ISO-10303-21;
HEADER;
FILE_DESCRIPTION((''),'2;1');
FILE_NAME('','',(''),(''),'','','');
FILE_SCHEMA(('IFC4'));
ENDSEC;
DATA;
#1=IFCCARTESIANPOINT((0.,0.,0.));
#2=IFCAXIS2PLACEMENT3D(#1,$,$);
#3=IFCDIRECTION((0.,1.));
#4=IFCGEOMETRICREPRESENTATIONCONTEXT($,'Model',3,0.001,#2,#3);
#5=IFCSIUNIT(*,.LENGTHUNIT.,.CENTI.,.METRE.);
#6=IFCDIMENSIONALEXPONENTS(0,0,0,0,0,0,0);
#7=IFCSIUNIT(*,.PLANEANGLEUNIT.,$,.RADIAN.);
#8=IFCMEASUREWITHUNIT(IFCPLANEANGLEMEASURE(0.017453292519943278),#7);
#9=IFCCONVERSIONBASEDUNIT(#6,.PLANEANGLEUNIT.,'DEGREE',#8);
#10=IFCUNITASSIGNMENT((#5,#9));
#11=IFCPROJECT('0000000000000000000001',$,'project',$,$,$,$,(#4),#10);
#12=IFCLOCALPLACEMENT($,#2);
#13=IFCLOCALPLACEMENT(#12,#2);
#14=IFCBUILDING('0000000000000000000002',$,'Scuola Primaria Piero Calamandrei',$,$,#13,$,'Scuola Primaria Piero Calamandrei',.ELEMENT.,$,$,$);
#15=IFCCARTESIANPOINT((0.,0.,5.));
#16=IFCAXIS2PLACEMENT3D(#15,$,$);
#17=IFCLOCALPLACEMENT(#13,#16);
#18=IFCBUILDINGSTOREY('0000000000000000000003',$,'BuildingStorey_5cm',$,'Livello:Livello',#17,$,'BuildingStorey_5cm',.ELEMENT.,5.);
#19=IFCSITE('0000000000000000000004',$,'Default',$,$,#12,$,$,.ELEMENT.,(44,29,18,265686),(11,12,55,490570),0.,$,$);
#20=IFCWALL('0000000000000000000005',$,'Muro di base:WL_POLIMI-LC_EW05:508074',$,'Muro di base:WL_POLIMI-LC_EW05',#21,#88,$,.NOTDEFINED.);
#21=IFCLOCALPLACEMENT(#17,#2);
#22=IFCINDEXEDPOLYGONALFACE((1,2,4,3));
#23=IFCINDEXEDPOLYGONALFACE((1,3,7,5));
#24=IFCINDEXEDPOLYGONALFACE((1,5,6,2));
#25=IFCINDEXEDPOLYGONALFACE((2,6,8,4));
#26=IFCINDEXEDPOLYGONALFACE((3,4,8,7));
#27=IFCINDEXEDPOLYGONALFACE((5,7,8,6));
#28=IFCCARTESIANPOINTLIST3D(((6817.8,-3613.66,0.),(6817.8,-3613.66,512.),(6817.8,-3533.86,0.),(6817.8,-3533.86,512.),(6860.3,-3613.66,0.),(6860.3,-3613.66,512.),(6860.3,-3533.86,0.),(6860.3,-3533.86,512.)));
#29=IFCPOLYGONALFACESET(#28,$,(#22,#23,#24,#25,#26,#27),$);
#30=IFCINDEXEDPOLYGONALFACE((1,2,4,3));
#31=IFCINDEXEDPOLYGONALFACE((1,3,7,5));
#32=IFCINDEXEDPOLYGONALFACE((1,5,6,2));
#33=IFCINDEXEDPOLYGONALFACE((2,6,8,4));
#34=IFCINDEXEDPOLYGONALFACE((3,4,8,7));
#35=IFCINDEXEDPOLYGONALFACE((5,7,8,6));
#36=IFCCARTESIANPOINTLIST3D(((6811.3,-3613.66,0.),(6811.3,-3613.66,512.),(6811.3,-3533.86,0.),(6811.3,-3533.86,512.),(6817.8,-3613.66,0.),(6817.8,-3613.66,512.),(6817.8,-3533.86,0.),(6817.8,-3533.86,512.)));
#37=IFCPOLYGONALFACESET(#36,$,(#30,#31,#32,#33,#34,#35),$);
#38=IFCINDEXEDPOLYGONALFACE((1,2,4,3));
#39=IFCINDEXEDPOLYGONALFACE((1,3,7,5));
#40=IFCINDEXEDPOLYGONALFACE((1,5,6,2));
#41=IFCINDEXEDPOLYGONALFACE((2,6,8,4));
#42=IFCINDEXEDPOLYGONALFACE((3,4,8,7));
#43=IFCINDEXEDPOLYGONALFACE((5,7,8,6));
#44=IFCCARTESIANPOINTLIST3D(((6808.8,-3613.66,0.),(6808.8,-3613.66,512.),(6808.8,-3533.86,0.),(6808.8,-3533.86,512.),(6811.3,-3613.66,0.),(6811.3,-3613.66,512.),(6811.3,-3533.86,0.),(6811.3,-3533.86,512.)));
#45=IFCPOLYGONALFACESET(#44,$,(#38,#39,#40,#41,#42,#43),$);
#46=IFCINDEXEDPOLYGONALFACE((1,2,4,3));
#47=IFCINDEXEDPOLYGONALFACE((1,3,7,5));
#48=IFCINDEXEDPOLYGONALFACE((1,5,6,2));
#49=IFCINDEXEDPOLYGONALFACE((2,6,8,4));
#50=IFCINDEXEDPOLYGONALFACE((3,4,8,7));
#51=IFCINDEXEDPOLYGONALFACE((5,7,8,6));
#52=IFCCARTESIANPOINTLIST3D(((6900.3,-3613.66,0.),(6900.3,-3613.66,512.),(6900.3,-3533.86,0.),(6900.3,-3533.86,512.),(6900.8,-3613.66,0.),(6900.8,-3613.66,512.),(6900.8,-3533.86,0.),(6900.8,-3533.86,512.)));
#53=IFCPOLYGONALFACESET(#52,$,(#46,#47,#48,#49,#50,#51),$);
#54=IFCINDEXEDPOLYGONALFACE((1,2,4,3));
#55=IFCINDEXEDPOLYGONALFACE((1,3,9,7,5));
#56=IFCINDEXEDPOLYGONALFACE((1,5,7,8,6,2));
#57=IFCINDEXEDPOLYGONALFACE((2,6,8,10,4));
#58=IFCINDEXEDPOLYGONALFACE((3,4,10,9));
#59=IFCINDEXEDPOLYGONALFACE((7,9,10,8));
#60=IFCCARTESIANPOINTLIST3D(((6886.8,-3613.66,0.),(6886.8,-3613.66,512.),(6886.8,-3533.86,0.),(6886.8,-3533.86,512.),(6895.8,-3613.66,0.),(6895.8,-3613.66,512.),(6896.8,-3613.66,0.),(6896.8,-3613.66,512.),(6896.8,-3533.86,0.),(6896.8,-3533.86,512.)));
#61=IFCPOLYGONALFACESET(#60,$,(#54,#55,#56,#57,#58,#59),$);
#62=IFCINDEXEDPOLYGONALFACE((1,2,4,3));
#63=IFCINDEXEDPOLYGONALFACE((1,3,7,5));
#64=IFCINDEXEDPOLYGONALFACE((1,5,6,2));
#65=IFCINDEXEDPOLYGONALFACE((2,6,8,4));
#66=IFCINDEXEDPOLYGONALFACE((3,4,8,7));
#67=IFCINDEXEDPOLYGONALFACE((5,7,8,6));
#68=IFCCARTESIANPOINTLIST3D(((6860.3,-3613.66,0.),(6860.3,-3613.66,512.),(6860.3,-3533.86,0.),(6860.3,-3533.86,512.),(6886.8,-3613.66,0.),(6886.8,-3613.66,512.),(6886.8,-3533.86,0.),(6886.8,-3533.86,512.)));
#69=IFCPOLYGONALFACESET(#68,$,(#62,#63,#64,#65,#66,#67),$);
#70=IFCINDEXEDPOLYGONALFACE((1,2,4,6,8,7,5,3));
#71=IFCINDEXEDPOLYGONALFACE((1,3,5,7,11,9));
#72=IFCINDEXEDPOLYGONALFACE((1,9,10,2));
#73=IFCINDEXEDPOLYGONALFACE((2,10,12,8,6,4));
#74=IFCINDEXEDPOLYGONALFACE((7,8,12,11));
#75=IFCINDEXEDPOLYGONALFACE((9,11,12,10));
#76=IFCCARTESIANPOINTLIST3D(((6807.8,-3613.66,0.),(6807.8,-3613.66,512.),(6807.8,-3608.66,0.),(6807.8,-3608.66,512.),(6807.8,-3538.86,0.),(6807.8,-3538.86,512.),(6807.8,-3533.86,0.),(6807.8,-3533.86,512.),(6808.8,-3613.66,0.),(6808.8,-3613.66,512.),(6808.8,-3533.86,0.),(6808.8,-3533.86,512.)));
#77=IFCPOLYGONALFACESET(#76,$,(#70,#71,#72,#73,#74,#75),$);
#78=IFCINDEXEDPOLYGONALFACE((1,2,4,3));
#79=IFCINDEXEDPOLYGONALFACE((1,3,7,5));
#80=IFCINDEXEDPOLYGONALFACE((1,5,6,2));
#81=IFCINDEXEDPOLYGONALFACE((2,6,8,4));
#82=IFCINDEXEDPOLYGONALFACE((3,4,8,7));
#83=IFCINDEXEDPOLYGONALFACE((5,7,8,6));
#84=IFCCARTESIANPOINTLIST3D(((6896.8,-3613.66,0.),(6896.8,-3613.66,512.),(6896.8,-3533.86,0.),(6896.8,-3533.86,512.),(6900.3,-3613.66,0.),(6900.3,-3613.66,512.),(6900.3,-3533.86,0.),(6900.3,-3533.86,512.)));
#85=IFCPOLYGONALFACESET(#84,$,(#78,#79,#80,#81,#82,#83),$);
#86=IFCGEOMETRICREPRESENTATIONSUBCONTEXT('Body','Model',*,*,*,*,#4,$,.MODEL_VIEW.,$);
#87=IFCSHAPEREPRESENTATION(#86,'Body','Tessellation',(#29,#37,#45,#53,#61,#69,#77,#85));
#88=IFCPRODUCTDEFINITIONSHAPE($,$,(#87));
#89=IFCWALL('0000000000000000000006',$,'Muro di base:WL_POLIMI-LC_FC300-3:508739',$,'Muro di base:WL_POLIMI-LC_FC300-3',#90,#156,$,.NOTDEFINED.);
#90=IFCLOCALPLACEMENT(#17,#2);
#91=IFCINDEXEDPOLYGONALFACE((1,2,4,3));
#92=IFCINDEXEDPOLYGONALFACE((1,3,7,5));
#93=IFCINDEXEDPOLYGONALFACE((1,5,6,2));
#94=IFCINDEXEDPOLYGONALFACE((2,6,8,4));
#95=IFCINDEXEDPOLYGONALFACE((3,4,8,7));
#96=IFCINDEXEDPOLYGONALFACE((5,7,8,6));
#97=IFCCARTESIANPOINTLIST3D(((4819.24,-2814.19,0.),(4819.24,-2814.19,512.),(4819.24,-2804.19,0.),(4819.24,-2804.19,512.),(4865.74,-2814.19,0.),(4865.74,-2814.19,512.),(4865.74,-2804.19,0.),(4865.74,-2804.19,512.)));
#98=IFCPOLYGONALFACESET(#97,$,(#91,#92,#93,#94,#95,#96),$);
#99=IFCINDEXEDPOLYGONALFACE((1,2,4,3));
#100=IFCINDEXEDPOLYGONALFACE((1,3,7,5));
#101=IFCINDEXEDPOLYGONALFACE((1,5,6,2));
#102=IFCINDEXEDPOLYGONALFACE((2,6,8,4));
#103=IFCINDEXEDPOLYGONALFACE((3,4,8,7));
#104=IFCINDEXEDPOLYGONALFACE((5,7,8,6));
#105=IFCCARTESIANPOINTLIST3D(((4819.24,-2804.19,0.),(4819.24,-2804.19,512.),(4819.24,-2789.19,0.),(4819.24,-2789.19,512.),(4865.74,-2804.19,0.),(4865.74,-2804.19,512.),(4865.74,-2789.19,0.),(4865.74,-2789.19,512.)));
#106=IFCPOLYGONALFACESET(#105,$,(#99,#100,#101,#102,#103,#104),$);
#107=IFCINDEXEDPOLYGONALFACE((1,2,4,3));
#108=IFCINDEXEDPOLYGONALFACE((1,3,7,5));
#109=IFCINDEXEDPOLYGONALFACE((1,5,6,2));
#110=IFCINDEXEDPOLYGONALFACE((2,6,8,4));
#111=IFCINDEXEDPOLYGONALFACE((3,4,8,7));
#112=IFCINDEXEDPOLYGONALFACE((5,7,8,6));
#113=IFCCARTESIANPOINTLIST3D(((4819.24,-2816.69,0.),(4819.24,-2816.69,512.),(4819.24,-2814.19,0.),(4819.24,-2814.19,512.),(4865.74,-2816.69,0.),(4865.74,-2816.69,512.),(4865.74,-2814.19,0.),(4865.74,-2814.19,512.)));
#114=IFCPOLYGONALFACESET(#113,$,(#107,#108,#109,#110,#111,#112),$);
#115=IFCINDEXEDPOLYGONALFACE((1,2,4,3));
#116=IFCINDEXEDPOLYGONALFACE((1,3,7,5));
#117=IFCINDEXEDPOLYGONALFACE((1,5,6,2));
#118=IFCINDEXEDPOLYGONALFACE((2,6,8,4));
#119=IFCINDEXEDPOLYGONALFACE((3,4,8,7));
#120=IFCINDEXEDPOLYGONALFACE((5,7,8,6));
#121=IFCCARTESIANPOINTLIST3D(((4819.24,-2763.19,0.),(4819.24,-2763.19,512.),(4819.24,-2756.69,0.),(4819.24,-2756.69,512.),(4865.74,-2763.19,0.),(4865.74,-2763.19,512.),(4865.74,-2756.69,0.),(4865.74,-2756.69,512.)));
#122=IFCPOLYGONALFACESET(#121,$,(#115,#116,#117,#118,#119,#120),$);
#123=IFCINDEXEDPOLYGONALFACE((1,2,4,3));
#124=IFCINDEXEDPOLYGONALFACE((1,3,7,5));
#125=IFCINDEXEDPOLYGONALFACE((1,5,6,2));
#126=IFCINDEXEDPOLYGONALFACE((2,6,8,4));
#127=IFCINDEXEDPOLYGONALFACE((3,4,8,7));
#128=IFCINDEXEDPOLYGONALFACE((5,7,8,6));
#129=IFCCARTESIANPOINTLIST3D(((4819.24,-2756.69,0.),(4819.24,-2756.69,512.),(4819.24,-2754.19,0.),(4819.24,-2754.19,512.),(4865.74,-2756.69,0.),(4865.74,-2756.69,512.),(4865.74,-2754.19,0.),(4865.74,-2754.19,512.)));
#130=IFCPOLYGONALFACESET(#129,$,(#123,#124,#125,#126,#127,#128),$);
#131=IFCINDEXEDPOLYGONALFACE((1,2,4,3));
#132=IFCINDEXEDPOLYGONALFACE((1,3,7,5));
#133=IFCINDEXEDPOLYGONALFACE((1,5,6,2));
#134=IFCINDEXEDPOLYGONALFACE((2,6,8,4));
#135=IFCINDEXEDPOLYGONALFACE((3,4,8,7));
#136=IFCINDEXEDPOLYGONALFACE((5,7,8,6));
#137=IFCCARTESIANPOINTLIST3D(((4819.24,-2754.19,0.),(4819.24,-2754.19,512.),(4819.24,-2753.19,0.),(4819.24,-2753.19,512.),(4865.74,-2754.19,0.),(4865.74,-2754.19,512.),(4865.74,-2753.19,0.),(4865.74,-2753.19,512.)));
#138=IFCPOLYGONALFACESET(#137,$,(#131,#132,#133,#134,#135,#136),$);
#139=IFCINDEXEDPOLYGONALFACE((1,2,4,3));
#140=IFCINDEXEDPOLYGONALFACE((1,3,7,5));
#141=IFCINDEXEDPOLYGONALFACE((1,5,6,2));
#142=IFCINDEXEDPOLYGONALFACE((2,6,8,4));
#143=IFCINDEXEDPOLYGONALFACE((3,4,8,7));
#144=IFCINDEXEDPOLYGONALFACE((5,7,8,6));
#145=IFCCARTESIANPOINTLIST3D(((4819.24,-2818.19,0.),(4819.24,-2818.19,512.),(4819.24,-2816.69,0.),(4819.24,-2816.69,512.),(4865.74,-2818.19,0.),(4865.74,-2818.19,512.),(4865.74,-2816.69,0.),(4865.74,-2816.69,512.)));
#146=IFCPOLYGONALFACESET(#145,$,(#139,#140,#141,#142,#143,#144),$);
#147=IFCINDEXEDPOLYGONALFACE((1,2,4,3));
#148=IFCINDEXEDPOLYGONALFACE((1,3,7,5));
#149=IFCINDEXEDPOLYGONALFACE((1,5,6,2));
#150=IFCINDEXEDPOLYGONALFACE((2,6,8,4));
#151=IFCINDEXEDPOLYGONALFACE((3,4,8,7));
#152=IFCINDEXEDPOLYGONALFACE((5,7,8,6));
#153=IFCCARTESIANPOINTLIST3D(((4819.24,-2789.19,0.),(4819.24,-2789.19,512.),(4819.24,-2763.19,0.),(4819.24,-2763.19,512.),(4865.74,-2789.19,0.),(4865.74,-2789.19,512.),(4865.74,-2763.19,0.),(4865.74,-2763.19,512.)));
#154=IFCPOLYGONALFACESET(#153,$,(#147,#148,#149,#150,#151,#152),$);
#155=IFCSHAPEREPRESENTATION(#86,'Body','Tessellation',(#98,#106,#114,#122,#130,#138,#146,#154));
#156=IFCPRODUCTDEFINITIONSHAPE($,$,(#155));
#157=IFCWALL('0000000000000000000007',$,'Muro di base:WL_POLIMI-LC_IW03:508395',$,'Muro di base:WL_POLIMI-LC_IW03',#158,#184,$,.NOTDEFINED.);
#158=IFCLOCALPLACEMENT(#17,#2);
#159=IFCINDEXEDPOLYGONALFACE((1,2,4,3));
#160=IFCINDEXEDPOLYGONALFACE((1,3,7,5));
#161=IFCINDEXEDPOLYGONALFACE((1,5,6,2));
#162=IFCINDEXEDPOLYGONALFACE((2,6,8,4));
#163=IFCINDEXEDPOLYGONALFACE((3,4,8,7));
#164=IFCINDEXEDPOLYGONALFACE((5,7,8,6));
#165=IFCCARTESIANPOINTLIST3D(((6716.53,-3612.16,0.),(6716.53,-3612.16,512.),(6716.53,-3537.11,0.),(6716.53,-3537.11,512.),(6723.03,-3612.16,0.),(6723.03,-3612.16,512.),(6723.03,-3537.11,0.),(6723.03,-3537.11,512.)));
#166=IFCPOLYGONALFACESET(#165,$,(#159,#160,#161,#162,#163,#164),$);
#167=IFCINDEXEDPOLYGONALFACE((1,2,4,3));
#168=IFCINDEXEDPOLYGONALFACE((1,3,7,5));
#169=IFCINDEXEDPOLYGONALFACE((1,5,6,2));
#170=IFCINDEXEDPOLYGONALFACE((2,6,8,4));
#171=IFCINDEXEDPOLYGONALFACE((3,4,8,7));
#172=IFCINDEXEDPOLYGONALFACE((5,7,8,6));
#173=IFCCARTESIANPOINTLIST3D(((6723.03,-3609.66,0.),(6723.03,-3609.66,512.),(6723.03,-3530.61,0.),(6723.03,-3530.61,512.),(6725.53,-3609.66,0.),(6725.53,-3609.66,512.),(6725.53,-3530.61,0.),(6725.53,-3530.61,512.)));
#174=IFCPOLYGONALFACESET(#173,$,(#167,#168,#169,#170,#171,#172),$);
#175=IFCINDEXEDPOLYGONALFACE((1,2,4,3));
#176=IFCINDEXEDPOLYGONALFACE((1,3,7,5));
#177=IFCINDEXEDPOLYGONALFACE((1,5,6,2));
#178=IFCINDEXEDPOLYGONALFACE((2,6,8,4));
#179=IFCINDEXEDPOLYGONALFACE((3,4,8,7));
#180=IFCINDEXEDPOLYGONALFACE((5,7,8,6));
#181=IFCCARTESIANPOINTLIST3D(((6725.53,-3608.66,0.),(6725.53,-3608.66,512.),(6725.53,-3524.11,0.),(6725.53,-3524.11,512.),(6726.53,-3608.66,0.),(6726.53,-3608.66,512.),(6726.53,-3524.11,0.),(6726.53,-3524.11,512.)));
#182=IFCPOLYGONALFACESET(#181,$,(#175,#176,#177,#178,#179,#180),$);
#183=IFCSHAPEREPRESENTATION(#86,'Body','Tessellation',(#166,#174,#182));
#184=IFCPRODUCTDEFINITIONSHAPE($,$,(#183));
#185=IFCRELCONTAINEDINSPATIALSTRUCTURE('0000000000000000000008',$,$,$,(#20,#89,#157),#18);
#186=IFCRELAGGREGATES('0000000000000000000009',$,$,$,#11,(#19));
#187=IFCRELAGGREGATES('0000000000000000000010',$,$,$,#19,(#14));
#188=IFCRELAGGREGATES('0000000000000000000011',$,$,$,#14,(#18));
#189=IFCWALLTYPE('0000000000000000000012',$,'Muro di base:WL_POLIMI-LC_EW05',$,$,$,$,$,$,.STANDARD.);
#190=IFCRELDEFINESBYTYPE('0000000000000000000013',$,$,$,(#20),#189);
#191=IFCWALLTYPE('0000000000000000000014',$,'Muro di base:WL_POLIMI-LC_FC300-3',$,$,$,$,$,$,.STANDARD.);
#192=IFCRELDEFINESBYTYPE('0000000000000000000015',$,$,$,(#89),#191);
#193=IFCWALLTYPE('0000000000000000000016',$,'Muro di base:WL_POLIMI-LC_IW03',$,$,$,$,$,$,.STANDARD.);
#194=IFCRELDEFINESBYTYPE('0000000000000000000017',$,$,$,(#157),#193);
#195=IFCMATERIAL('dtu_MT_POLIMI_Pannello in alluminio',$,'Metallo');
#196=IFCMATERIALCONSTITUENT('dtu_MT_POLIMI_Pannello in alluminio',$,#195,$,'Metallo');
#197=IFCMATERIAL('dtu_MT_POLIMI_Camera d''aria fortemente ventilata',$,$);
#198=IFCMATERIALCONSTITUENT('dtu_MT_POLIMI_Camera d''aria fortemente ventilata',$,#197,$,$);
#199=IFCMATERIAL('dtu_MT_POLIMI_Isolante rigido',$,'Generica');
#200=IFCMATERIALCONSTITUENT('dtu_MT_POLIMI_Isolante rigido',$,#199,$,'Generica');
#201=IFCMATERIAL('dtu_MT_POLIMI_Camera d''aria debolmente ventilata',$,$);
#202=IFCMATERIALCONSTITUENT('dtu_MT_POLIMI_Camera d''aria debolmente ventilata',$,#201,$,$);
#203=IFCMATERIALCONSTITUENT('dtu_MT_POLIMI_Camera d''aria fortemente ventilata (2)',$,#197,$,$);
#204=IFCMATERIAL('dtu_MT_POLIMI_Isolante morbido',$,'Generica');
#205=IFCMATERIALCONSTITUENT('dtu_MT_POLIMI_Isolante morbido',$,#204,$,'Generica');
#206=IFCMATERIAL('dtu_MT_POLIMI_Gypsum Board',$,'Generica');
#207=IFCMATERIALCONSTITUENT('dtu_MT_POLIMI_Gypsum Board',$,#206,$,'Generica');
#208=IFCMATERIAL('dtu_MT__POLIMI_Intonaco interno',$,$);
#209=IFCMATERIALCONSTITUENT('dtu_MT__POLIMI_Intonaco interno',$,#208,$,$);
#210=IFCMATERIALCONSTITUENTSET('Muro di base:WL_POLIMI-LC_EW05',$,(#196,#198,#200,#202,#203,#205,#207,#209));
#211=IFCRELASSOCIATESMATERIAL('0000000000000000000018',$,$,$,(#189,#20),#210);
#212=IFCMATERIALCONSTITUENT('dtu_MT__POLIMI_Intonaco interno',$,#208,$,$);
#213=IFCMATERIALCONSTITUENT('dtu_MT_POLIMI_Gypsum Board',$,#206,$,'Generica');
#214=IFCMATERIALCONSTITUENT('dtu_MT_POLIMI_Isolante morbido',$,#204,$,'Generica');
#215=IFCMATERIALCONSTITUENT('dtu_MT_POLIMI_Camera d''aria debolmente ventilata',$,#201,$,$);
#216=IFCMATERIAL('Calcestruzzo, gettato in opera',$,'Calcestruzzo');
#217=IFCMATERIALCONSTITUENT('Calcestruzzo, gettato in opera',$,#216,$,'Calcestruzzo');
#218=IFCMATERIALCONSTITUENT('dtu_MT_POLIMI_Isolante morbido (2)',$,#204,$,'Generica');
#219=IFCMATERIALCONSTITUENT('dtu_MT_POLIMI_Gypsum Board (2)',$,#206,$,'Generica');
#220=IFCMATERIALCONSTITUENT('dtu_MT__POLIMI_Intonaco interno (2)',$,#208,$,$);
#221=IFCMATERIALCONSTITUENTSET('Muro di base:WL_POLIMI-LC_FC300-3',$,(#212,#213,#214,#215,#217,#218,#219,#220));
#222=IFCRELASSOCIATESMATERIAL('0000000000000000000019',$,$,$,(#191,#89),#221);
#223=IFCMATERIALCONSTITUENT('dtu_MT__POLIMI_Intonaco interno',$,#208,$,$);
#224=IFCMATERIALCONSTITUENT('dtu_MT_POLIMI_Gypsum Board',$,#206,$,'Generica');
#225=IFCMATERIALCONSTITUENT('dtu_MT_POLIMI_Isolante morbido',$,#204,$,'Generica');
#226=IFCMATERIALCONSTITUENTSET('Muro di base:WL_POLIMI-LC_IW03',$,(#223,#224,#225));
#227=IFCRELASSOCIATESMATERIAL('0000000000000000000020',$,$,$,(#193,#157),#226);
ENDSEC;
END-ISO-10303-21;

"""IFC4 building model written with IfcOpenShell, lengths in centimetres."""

from ifc_helpers import new_model, entity, si_unit, converted_unit, direction, frame, origin, place, context, subcontext, project, spatial, indexed_curve, outline, extrude, material, constituent, constituent_set, type_object, element, save


model = new_model("IFC4")

# Units and contexts
model_context = context("Model", 3, precision=0.001, world=origin(), true_north=direction((0.0, 1.0)))
body_context = subcontext(model_context, "Body", "Model", "MODEL_VIEW")
ifc_project = project(units=[si_unit("LENGTHUNIT", "METRE", prefix="CENTI"), converted_unit("PLANEANGLEUNIT", "DEGREE", entity("IfcPlaneAngleMeasure", 0.017453292519943278), si_unit("PLANEANGLEUNIT", "RADIAN"), dimensions=[0, 0, 0, 0, 0, 0, 0])], contexts=[model_context])

# Site, building, storey
site_placement = place(None, origin())
site = spatial("IfcSite", under=ifc_project, at=site_placement, Name="Default", CompositionType="ELEMENT", RefLatitude=(44, 29, 18, 265686), RefLongitude=(11, 12, 55, 490570), RefElevation=0.0)
building_placement = place(site_placement, origin())
building = spatial("IfcBuilding", under=site, at=building_placement, Name="Scuola Primaria Piero Calamandrei", LongName="Scuola Primaria Piero Calamandrei", CompositionType="ELEMENT")
storey_placement = place(building_placement, frame((0.0, 0.0, 5.0)))
storey = spatial("IfcBuildingStorey", under=building, at=storey_placement, Name="BuildingStorey_5cm", ObjectType="Livello:Livello", LongName="BuildingStorey_5cm", CompositionType="ELEMENT", Elevation=5.0)

# Shared definitions
ifc_material_1 = material(Name="dtu_MT_POLIMI_Isolante rigido", Category="Generica")

# Walls
ifc_material_2 = material(Name="dtu_MT_POLIMI_Pannello in alluminio", Category="Metallo")
ifc_constituent_1 = constituent(ifc_material_2, Name="dtu_MT_POLIMI_Pannello in alluminio", Category="Metallo")
ifc_material_3 = material(Name="dtu_MT_POLIMI_Camera d'aria fortemente ventilata")
ifc_constituent_2 = constituent(ifc_material_3, Name="dtu_MT_POLIMI_Camera d'aria fortemente ventilata")
ifc_constituent_3 = constituent(ifc_material_1, Name="dtu_MT_POLIMI_Isolante rigido", Category="Generica")
ifc_material_4 = material(Name="dtu_MT_POLIMI_Camera d'aria debolmente ventilata")
ifc_constituent_4 = constituent(ifc_material_4, Name="dtu_MT_POLIMI_Camera d'aria debolmente ventilata")
ifc_constituent_5 = constituent(ifc_material_3, Name="dtu_MT_POLIMI_Camera d'aria fortemente ventilata (2)")
ifc_material_5 = material(Name="dtu_MT_POLIMI_Isolante morbido", Category="Generica")
ifc_constituent_6 = constituent(ifc_material_5, Name="dtu_MT_POLIMI_Isolante morbido", Category="Generica")
ifc_material_6 = material(Name="dtu_MT_POLIMI_Gypsum Board", Category="Generica")
ifc_constituent_7 = constituent(ifc_material_6, Name="dtu_MT_POLIMI_Gypsum Board", Category="Generica")
ifc_material_7 = material(Name="dtu_MT__POLIMI_Intonaco interno")
ifc_constituent_8 = constituent(ifc_material_7, Name="dtu_MT__POLIMI_Intonaco interno")
ifc_constituent_set_1 = constituent_set(constituents=[ifc_constituent_1, ifc_constituent_2, ifc_constituent_3, ifc_constituent_4, ifc_constituent_5, ifc_constituent_6, ifc_constituent_7, ifc_constituent_8], Name="Muro di base:WL_POLIMI-LC_EW05")
wall_type_1 = type_object("IfcWallType", Name="Muro di base:WL_POLIMI-LC_EW05", PredefinedType="STANDARD", material=ifc_constituent_set_1)
wall_1_placement = place(storey_placement, frame((6854.3, -3533.86, 0.0), z_axis=(0.0, 0.0, 1.0), x_axis=(0.0, -1.0, 0.0)))
element("IfcWall", 1, at=wall_1_placement, inside=storey, type_object=wall_type_1, material=ifc_constituent_set_1, Name="Muro di base:WL_POLIMI-LC_EW05:508074", ObjectType="Muro di base:WL_POLIMI-LC_EW05", PredefinedType="NOTDEFINED", context=body_context, shape_type="SweptSolid", body=[
    extrude(outline(indexed_curve([(-39.9, -21.25), (39.9, -21.25), (39.9, 21.25), (-39.9, 21.25), (-39.9, -21.25)], self_intersect=False)), frame((39.9, -15.25, 0.0)), (0.0, 0.0, 1.0), 512.0),
    extrude(outline(indexed_curve([(-39.9, -3.25), (39.9, -3.25), (39.9, 3.25), (-39.9, 3.25), (-39.9, -3.25)], self_intersect=False)), frame((39.9, -39.75, 0.0)), (0.0, 0.0, 1.0), 512.0),
    extrude(outline(indexed_curve([(-39.9, -1.25), (39.9, -1.25), (39.9, 1.25), (-39.9, 1.25), (-39.9, -1.25)], self_intersect=False)), frame((39.9, -44.25, 0.0)), (0.0, 0.0, 1.0), 512.0),
    extrude(outline(indexed_curve([(-0.25, -39.9), (0.25, -39.9), (0.25, 39.9), (-0.25, 39.9), (-0.25, -39.9)], self_intersect=False)), frame((39.9, 46.25, 0.0), z_axis=(0.0, 0.0, 1.0), x_axis=(0.0, -1.0, 0.0)), (0.0, 0.0, 1.0), 512.0),
    extrude(outline(indexed_curve([(-47.88, -5.8), (31.92, -5.8), (31.92, 3.2), (31.92, 4.2), (-47.88, 4.2), (-47.88, -5.8)], self_intersect=False)), frame((47.88, 38.3, 0.0)), (0.0, 0.0, 1.0), 512.0),
    extrude(outline(indexed_curve([(-39.9, -13.25), (39.9, -13.25), (39.9, 13.25), (-39.9, 13.25), (-39.9, -13.25)], self_intersect=False)), frame((39.9, 19.25, 0.0)), (0.0, 0.0, 1.0), 512.0),
    extrude(outline(indexed_curve([(-34.9, -0.33), (34.9, -0.33), (39.9, -0.33), (39.9, 0.67), (-39.9, 0.67), (-39.9, -0.33), (-34.9, -0.33)], self_intersect=False)), frame((39.9, -46.17, 0.0)), (0.0, 0.0, 1.0), 512.0),
    extrude(outline(indexed_curve([(-39.9, -1.75), (39.9, -1.75), (39.9, 1.75), (-39.9, 1.75), (-39.9, -1.75)], self_intersect=False)), frame((39.9, 44.25, 0.0)), (0.0, 0.0, 1.0), 512.0),
])
ifc_constituent_9 = constituent(ifc_material_7, Name="dtu_MT__POLIMI_Intonaco interno")
ifc_constituent_10 = constituent(ifc_material_6, Name="dtu_MT_POLIMI_Gypsum Board", Category="Generica")
ifc_constituent_11 = constituent(ifc_material_5, Name="dtu_MT_POLIMI_Isolante morbido", Category="Generica")
ifc_constituent_12 = constituent(ifc_material_4, Name="dtu_MT_POLIMI_Camera d'aria debolmente ventilata")
ifc_material_8 = material(Name="Calcestruzzo, gettato in opera", Category="Calcestruzzo")
ifc_constituent_13 = constituent(ifc_material_8, Name="Calcestruzzo, gettato in opera", Category="Calcestruzzo")
ifc_constituent_14 = constituent(ifc_material_5, Name="dtu_MT_POLIMI_Isolante morbido (2)", Category="Generica")
ifc_constituent_15 = constituent(ifc_material_6, Name="dtu_MT_POLIMI_Gypsum Board (2)", Category="Generica")
ifc_constituent_16 = constituent(ifc_material_7, Name="dtu_MT__POLIMI_Intonaco interno (2)")
ifc_constituent_set_2 = constituent_set(constituents=[ifc_constituent_9, ifc_constituent_10, ifc_constituent_11, ifc_constituent_12, ifc_constituent_13, ifc_constituent_14, ifc_constituent_15, ifc_constituent_16], Name="Muro di base:WL_POLIMI-LC_FC300-3")
wall_type_2 = type_object("IfcWallType", Name="Muro di base:WL_POLIMI-LC_FC300-3", PredefinedType="STANDARD", material=ifc_constituent_set_2)
wall_2_placement = place(storey_placement, frame((4865.74, -2785.69, 0.0), z_axis=(0.0, 0.0, 1.0), x_axis=(-1.0, 0.0, 0.0)))
element("IfcWall", 2, at=wall_2_placement, inside=storey, type_object=wall_type_2, material=ifc_constituent_set_2, Name="Muro di base:WL_POLIMI-LC_FC300-3:508739", ObjectType="Muro di base:WL_POLIMI-LC_FC300-3", PredefinedType="NOTDEFINED", context=body_context, shape_type="SweptSolid", body=[
    extrude(outline(indexed_curve([(-23.25, -5.0), (23.25, -5.0), (23.25, 5.0), (-23.25, 5.0), (-23.25, -5.0)], self_intersect=False)), frame((23.25, 23.5, 0.0)), (0.0, 0.0, 1.0), 512.0),
    extrude(outline(indexed_curve([(-23.25, -7.5), (23.25, -7.5), (23.25, 7.5), (-23.25, 7.5), (-23.25, -7.5)], self_intersect=False)), frame((23.25, 11.0, 0.0)), (0.0, 0.0, 1.0), 512.0),
    extrude(outline(indexed_curve([(-23.25, -1.25), (23.25, -1.25), (23.25, 1.25), (-23.25, 1.25), (-23.25, -1.25)], self_intersect=False)), frame((23.25, 29.75, 0.0)), (0.0, 0.0, 1.0), 512.0),
    extrude(outline(indexed_curve([(-23.25, -3.25), (23.25, -3.25), (23.25, 3.25), (-23.25, 3.25), (-23.25, -3.25)], self_intersect=False)), frame((23.25, -25.75, 0.0)), (0.0, 0.0, 1.0), 512.0),
    extrude(outline(indexed_curve([(-23.25, -1.25), (23.25, -1.25), (23.25, 1.25), (-23.25, 1.25), (-23.25, -1.25)], self_intersect=False)), frame((23.25, -30.25, 0.0)), (0.0, 0.0, 1.0), 512.0),
    extrude(outline(indexed_curve([(-0.5, -23.25), (0.5, -23.25), (0.5, 23.25), (-0.5, 23.25), (-0.5, -23.25)], self_intersect=False)), frame((23.25, -32.0, 0.0), z_axis=(0.0, 0.0, 1.0), x_axis=(0.0, 1.0, 0.0)), (0.0, 0.0, 1.0), 512.0),
    extrude(outline(indexed_curve([(-0.75, -23.25), (0.75, -23.25), (0.75, 23.25), (-0.75, 23.25), (-0.75, -23.25)], self_intersect=False)), frame((23.25, 31.75, 0.0), z_axis=(0.0, 0.0, 1.0), x_axis=(0.0, -1.0, 0.0)), (0.0, 0.0, 1.0), 512.0),
    extrude(outline(indexed_curve([(-23.25, -13.0), (23.25, -13.0), (23.25, 13.0), (-23.25, 13.0), (-23.25, -13.0)], self_intersect=False)), frame((23.25, -9.5, 0.0)), (0.0, 0.0, 1.0), 512.0),
])

# Wall
ifc_constituent_17 = constituent(ifc_material_7, Name="dtu_MT__POLIMI_Intonaco interno")
ifc_constituent_18 = constituent(ifc_material_6, Name="dtu_MT_POLIMI_Gypsum Board", Category="Generica")
ifc_constituent_19 = constituent(ifc_material_5, Name="dtu_MT_POLIMI_Isolante morbido", Category="Generica")
ifc_constituent_set_3 = constituent_set(constituents=[ifc_constituent_17, ifc_constituent_18, ifc_constituent_19], Name="Muro di base:WL_POLIMI-LC_IW03")
wall_type_3 = type_object("IfcWallType", Name="Muro di base:WL_POLIMI-LC_IW03", PredefinedType="STANDARD", material=ifc_constituent_set_3)
wall_3_placement = place(storey_placement, frame((6721.53, -3544.61, 0.0), z_axis=(0.0, 0.0, 1.0), x_axis=(0.0, -1.0, 0.0)))
element("IfcWall", 3, at=wall_3_placement, inside=storey, type_object=wall_type_3, material=ifc_constituent_set_3, Name="Muro di base:WL_POLIMI-LC_IW03:508395", ObjectType="Muro di base:WL_POLIMI-LC_IW03", PredefinedType="NOTDEFINED", context=body_context, shape_type="SweptSolid", body=[
    extrude(outline(indexed_curve([(-3.25, -37.53), (3.25, -37.53), (3.25, 37.53), (-3.25, 37.53), (-3.25, -37.53)], self_intersect=False)), frame((30.03, -1.75, 0.0), z_axis=(0.0, 0.0, 1.0), x_axis=(0.0, 1.0, 0.0)), (0.0, 0.0, 1.0), 512.0),
    extrude(outline(indexed_curve([(-39.53, -1.25), (39.53, -1.25), (39.53, 1.25), (-39.53, 1.25), (-39.53, -1.25)], self_intersect=False)), frame((25.53, 2.75, 0.0)), (0.0, 0.0, 1.0), 512.0),
    extrude(outline(indexed_curve([(-0.5, -42.28), (0.5, -42.28), (0.5, 42.28), (-0.5, 42.28), (-0.5, -42.28)], self_intersect=False)), frame((21.78, 4.5, 0.0), z_axis=(0.0, 0.0, 1.0), x_axis=(0.0, -1.0, 0.0)), (0.0, 0.0, 1.0), 512.0),
])

save(model, "model.ifc")
